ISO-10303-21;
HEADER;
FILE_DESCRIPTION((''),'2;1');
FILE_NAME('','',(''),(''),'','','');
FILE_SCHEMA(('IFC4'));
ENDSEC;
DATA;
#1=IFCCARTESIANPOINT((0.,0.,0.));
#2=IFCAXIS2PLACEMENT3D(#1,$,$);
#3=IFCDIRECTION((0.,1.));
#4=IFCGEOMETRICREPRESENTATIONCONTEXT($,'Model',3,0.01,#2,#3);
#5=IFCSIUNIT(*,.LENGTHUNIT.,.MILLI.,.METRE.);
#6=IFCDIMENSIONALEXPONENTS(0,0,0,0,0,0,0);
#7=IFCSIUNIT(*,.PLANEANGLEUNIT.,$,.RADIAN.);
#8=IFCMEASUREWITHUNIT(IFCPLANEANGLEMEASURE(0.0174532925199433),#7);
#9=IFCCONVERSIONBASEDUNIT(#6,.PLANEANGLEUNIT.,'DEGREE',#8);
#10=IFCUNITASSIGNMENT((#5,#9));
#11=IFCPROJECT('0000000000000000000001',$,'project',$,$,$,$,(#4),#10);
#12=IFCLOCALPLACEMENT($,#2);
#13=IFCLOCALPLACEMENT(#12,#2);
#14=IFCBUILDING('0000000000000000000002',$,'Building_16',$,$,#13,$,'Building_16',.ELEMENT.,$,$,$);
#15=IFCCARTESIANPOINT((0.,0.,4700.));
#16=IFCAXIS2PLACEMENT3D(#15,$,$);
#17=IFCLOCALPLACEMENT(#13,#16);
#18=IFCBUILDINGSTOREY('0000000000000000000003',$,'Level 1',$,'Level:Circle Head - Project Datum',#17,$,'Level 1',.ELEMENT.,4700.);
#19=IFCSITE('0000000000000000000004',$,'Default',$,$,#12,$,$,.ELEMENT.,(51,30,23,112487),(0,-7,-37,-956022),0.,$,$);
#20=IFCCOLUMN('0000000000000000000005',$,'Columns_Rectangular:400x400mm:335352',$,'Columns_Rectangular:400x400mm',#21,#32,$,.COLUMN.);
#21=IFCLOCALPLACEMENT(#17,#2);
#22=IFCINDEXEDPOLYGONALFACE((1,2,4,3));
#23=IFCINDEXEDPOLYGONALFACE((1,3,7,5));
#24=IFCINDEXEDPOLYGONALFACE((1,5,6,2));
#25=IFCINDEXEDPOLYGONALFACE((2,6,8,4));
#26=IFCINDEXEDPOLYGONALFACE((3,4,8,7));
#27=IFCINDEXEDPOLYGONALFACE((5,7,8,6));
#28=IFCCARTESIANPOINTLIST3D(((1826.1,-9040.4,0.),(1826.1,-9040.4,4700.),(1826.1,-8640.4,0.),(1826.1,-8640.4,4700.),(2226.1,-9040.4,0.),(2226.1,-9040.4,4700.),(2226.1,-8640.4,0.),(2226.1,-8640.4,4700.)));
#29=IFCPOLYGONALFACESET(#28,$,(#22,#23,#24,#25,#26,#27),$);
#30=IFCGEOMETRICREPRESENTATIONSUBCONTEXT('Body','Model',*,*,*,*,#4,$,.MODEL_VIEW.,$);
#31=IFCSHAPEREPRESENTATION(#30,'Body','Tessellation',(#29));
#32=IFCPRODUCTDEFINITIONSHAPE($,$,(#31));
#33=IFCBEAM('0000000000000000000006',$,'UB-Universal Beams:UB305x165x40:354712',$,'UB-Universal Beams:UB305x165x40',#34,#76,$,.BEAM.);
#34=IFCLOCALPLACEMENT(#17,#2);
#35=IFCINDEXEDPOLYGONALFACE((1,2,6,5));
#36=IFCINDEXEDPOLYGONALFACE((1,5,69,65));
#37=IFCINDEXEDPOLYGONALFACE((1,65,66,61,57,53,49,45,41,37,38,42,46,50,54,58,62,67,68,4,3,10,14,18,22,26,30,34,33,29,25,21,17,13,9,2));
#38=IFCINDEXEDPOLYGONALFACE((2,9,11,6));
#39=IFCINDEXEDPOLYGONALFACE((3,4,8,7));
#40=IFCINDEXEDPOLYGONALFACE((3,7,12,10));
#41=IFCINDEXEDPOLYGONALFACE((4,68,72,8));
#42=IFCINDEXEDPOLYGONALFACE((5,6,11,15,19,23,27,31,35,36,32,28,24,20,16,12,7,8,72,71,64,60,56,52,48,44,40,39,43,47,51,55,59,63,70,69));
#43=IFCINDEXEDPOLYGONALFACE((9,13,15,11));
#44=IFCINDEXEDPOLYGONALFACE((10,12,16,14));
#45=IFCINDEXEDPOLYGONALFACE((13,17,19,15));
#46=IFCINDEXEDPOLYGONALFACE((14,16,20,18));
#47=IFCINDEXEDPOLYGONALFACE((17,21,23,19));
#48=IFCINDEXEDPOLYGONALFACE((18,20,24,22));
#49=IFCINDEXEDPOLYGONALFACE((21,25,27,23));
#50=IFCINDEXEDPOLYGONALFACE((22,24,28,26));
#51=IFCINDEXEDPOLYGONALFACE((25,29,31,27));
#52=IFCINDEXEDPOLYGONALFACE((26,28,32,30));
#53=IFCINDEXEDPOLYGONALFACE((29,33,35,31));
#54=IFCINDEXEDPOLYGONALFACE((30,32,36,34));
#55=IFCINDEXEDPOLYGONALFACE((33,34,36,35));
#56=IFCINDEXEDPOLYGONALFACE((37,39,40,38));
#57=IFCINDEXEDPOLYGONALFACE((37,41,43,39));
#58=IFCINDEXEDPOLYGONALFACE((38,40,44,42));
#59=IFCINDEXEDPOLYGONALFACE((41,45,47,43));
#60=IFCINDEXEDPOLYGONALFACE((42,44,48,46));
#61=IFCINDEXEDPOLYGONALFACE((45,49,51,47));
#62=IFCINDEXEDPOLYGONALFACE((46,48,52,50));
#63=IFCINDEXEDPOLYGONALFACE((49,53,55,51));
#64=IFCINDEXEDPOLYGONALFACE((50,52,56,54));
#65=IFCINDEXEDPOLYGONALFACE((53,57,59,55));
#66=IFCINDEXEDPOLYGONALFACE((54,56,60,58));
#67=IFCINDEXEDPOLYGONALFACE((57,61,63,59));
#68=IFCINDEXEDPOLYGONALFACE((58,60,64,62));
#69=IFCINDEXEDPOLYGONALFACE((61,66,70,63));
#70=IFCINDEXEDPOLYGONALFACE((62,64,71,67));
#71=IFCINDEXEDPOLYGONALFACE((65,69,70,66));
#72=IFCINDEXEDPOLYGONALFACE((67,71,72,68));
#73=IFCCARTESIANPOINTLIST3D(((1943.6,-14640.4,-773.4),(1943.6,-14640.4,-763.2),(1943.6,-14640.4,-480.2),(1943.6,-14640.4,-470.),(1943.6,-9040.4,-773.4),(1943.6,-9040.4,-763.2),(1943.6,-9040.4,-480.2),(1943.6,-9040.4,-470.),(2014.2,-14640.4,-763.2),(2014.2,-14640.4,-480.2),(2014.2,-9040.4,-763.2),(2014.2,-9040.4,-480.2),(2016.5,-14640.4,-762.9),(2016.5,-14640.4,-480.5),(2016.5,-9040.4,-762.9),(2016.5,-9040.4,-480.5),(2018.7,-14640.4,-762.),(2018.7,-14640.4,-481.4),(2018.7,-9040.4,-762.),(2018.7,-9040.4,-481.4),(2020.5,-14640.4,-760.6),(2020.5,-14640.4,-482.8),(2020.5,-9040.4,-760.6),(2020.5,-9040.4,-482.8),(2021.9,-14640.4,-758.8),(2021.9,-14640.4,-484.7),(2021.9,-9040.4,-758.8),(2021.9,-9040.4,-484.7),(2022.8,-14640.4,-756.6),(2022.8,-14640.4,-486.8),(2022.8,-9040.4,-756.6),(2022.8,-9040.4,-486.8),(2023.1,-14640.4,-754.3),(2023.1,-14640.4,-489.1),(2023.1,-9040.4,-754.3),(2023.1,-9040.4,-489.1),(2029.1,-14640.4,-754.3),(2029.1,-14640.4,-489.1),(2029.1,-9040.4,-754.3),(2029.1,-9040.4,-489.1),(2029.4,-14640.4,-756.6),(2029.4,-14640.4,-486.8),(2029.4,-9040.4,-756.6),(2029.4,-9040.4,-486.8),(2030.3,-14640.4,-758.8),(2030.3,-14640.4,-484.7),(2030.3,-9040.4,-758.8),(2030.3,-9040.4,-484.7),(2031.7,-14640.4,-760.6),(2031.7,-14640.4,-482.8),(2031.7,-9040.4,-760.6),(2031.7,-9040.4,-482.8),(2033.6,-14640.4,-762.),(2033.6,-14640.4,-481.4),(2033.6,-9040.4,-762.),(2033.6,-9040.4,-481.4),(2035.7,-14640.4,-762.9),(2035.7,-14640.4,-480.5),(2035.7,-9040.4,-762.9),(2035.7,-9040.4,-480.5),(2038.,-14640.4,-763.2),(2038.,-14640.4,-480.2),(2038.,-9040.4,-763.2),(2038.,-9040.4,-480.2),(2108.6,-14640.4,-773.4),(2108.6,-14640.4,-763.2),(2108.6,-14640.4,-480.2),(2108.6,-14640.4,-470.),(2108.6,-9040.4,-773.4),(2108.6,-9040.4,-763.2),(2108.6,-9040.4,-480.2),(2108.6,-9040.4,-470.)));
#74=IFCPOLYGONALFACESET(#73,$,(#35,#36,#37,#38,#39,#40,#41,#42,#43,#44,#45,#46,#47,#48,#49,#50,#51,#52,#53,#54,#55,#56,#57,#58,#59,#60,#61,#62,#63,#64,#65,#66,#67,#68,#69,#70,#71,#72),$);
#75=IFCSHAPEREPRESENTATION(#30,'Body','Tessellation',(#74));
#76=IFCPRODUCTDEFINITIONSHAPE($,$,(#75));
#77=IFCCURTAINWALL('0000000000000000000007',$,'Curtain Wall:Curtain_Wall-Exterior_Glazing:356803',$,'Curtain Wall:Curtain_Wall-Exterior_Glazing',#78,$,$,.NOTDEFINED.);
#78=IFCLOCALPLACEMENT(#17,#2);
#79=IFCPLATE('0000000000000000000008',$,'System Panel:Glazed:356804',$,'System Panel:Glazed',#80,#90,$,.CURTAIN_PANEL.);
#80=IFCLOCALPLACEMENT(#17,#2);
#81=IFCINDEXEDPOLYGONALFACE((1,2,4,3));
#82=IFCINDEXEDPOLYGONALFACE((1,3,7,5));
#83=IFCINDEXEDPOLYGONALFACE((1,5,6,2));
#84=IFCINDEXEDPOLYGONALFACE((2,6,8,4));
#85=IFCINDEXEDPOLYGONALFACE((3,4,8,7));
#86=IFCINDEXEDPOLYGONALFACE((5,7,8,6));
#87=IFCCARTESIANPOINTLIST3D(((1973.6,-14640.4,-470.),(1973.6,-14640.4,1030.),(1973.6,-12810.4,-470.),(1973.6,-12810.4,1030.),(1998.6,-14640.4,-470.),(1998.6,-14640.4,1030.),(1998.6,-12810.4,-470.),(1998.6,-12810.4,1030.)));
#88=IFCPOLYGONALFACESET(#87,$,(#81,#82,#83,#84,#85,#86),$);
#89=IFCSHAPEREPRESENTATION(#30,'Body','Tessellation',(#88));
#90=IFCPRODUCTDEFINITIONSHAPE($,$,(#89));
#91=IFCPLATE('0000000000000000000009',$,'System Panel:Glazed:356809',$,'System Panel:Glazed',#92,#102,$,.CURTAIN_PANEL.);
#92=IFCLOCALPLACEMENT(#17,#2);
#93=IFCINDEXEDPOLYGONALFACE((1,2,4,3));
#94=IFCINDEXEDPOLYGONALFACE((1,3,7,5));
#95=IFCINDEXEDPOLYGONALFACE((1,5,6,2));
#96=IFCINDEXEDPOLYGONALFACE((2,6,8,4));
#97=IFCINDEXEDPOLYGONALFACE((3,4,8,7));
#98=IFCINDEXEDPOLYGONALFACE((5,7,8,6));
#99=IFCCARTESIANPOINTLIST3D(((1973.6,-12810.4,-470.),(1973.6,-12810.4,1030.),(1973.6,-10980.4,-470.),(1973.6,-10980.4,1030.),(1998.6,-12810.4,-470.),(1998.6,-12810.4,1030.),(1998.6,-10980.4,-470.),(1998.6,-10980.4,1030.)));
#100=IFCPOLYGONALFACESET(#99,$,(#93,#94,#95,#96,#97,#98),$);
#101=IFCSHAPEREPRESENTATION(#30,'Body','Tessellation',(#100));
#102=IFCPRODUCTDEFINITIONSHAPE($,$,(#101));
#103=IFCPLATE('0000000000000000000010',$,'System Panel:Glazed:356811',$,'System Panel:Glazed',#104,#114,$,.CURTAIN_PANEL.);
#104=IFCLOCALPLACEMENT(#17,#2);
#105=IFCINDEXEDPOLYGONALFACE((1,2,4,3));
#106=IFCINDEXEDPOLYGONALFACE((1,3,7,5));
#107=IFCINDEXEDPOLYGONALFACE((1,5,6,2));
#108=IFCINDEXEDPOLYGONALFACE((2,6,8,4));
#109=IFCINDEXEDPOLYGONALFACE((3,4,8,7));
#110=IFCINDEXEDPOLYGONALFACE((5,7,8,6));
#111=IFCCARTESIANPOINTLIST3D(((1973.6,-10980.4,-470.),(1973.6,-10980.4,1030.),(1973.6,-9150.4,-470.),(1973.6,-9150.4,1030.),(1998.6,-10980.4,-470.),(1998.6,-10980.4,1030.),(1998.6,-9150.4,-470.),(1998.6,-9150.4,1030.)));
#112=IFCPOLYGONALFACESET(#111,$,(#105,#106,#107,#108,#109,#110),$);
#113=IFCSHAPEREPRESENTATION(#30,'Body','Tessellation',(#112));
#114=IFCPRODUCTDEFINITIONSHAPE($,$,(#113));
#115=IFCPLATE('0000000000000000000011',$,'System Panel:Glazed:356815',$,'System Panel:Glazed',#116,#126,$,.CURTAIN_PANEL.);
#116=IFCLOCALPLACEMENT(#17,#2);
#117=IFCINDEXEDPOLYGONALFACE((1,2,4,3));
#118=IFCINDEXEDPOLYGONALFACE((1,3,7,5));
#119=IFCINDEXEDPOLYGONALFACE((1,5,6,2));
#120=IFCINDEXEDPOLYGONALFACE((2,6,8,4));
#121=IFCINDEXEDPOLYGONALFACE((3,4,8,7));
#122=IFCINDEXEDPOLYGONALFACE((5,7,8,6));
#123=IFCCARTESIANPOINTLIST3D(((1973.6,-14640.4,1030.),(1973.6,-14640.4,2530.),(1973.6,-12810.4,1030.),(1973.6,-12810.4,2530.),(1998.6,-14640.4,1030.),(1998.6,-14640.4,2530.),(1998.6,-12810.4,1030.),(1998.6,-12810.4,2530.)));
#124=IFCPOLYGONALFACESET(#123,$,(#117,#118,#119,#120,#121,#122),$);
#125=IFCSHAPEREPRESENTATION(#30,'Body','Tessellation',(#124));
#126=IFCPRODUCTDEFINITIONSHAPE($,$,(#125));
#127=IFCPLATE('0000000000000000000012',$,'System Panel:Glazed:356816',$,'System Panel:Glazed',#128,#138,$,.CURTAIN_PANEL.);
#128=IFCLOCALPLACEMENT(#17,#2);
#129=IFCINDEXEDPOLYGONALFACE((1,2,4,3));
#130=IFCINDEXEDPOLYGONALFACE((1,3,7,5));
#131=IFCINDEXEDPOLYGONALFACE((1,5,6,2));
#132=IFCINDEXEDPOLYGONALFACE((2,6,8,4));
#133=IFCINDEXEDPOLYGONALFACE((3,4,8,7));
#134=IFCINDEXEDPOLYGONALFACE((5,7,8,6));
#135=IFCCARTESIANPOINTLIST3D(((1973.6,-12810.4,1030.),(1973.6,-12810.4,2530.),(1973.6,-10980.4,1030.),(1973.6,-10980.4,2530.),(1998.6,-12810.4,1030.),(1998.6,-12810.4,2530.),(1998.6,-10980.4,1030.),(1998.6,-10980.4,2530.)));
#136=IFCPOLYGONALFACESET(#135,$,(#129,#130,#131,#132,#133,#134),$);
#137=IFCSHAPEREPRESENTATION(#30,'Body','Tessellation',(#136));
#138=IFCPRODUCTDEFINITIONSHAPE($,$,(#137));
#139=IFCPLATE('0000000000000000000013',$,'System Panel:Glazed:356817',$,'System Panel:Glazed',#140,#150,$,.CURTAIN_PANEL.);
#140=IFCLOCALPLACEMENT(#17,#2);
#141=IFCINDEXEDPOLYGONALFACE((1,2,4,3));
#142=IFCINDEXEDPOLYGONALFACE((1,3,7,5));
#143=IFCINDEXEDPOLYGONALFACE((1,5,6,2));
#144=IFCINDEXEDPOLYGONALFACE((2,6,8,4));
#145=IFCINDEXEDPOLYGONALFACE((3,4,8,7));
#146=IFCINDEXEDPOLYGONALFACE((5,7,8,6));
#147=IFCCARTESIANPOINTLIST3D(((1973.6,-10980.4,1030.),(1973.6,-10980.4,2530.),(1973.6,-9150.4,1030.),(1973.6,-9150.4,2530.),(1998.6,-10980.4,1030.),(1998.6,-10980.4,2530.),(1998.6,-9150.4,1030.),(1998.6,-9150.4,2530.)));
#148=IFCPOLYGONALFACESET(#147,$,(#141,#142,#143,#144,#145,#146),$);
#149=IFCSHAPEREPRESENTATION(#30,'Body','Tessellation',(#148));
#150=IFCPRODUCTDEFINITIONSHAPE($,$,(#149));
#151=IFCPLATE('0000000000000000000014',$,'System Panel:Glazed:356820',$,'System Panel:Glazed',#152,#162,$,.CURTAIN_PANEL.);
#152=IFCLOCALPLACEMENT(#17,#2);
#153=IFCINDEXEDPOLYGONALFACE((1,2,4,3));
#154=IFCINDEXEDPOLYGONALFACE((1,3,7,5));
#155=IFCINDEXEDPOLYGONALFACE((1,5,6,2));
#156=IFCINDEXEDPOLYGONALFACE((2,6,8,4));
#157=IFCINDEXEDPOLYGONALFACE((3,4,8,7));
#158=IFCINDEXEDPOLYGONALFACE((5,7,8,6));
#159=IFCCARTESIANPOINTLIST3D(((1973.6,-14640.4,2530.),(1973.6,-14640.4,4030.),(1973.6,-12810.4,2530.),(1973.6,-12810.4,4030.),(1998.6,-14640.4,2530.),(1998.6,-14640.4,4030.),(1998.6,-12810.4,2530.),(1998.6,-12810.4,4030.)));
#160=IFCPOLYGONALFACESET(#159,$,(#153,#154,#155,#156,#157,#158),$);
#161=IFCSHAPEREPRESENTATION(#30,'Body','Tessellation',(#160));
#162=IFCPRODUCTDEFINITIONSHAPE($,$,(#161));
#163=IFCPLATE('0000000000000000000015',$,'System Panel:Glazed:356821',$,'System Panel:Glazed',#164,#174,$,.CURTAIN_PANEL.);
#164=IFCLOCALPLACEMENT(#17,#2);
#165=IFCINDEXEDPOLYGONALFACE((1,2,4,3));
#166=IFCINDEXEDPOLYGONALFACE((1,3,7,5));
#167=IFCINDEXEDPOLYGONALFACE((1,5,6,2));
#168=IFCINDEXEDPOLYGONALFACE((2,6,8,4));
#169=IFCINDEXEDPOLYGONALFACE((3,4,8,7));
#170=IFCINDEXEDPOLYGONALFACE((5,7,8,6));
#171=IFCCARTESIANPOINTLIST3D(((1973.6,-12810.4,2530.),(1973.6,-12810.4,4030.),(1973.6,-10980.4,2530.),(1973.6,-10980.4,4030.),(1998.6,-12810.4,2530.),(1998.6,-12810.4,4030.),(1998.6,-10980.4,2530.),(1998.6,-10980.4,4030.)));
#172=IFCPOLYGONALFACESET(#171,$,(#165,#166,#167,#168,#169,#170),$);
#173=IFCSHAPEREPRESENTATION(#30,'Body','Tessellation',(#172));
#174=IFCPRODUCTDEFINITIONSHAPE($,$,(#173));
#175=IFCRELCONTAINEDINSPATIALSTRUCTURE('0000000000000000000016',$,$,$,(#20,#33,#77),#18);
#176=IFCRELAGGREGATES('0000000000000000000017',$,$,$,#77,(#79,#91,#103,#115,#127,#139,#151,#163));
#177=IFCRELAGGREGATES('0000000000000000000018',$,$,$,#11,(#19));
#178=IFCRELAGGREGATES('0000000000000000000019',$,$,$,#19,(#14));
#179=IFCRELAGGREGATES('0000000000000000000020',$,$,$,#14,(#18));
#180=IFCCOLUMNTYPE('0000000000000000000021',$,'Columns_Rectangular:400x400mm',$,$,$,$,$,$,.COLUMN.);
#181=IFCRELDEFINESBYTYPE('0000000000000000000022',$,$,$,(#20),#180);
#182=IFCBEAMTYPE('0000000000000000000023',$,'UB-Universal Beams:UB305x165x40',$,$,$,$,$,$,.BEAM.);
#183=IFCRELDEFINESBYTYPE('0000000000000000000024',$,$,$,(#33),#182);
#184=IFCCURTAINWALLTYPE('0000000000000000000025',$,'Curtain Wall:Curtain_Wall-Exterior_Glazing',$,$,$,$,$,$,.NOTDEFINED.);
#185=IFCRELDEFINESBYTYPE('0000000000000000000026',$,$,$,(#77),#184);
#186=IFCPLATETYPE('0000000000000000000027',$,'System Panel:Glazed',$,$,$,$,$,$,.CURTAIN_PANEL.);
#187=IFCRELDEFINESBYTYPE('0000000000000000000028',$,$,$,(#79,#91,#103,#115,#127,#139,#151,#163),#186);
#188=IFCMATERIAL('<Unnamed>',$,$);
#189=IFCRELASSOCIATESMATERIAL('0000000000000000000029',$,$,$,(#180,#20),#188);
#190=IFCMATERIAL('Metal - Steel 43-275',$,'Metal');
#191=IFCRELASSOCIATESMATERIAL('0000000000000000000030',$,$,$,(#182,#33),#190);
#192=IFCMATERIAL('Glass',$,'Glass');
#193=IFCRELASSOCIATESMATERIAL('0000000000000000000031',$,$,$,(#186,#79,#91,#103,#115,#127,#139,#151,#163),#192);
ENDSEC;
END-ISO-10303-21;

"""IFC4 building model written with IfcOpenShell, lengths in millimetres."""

from ifc_helpers import new_model, entity, si_unit, converted_unit, direction, frame, origin, place, context, subcontext, project, spatial, line, arc, indexed_curve, outline, extrude, source, transform, mapped, material, type_object, type_shapes, element, aggregate, save


model = new_model("IFC4")

# Units and contexts
model_context = context("Model", 3, precision=0.01, world=origin(), true_north=direction((0.0, 1.0)))
body_context = subcontext(model_context, "Body", "Model", "MODEL_VIEW")
ifc_project = project(units=[si_unit("LENGTHUNIT", "METRE", prefix="MILLI"), converted_unit("PLANEANGLEUNIT", "DEGREE", entity("IfcPlaneAngleMeasure", 0.0174532925199433), si_unit("PLANEANGLEUNIT", "RADIAN"), dimensions=[0, 0, 0, 0, 0, 0, 0])], contexts=[model_context])

# Site, building, storey
site_placement = place(None, origin())
site = spatial("IfcSite", under=ifc_project, at=site_placement, Name="Default", CompositionType="ELEMENT", RefLatitude=(51, 30, 23, 112487), RefLongitude=(0, -7, -37, -956022), RefElevation=0.0)
building_placement = place(site_placement, origin())
building = spatial("IfcBuilding", under=site, at=building_placement, Name="Building_16", LongName="Building_16", CompositionType="ELEMENT")
storey_placement = place(building_placement, frame((0.0, 0.0, 4700.0)))
storey = spatial("IfcBuildingStorey", under=building, at=storey_placement, Name="Level 1", ObjectType="Level:Circle Head - Project Datum", LongName="Level 1", CompositionType="ELEMENT", Elevation=4700.0)

# Column
ifc_material_1 = material(Name="<Unnamed>")
column_type = type_object("IfcColumnType", Name="Columns_Rectangular:400x400mm", PredefinedType="COLUMN", material=ifc_material_1)
shared_shape_1 = source(origin(), body_context, "Body", "SweptSolid", [
    extrude(outline(indexed_curve([(-200.0, -200.0), (200.0, -200.0), (200.0, 200.0), (-200.0, 200.0), (-200.0, -200.0)], self_intersect=False)), frame((0.0, 0.0, 4700.0), z_axis=(0.0, 0.0, 1.0), x_axis=(-1.0, 0.0, 0.0)), (0.0, 0.0, 1.0), 4700.0),
])
type_shapes(column_type, [shared_shape_1])
column_placement = place(storey_placement, frame((2026.1, -8840.4, -4700.0)))
element("IfcColumn", 1, at=column_placement, inside=storey, type_object=column_type, material=ifc_material_1, Name="Columns_Rectangular:400x400mm:335352", ObjectType="Columns_Rectangular:400x400mm", PredefinedType="COLUMN", context=body_context, shape_type="MappedRepresentation", body=[
    mapped(shared_shape_1, transform((0.0, 0.0, 0.0), scale=1.0)),
])

# Beam
ifc_material_2 = material(Name="Metal - Steel 43-275", Category="Metal")
beam_type = type_object("IfcBeamType", Name="UB-Universal Beams:UB305x165x40", PredefinedType="BEAM", material=ifc_material_2)
shared_shape_2 = source(origin(), body_context, "Body", "SweptSolid", [
    extrude(outline(indexed_curve([(-82.5, -141.5), (-82.5, -151.7), (82.5, -151.7), (82.5, -141.5), (11.9, -141.5), (5.6, -138.9), (3.0, -132.6), (3.0, 132.6), (5.6, 138.9), (11.9, 141.5), (82.5, 141.5), (82.5, 151.7), (-82.5, 151.7), (-82.5, 141.5), (-11.9, 141.5), (-5.6, 138.9), (-3.0, 132.6), (-3.0, -132.6), (-5.6, -138.9), (-11.9, -141.5)], segments=[line(1, 2, 3, 4, 5), arc(5, 6, 7), line(7, 8), arc(8, 9, 10), line(10, 11, 12, 13, 14, 15), arc(15, 16, 17), line(17, 18), arc(18, 19, 20), line(20, 1)], self_intersect=False)), frame((-2800.0, 0.0, 0.0), z_axis=(-1.0, 0.0, 0.0), x_axis=(0.0, -1.0, 0.0)), (0.0, 0.0, -1.0), 5600.0),
])
type_shapes(beam_type, [shared_shape_2])
beam_placement = place(storey_placement, frame((2026.1, -11840.4, -621.7), z_axis=(0.0, 0.0, 1.0), x_axis=(0.0, 1.0, 0.0)))
element("IfcBeam", 2, at=beam_placement, inside=storey, type_object=beam_type, material=ifc_material_2, Name="UB-Universal Beams:UB305x165x40:354712", ObjectType="UB-Universal Beams:UB305x165x40", PredefinedType="BEAM", context=body_context, shape_type="MappedRepresentation", body=[
    mapped(shared_shape_2, transform((0.0, 0.0, 0.0), scale=1.0)),
])

# Curtain wall, plates
curtain_wall_type = type_object("IfcCurtainWallType", Name="Curtain Wall:Curtain_Wall-Exterior_Glazing", PredefinedType="NOTDEFINED")
curtain_wall_1_placement = place(storey_placement, frame((0.0, 0.0, -4700.0)))
curtain_wall_1 = element("IfcCurtainWall", 3, at=curtain_wall_1_placement, inside=storey, type_object=curtain_wall_type, Name="Curtain Wall:Curtain_Wall-Exterior_Glazing:356803", ObjectType="Curtain Wall:Curtain_Wall-Exterior_Glazing", PredefinedType="NOTDEFINED")
ifc_material_3 = material(Name="Glass", Category="Glass")
plate_type_1 = type_object("IfcPlateType", Name="System Panel:Glazed", PredefinedType="CURTAIN_PANEL", material=ifc_material_3)
shared_shape_3 = source(origin(), body_context, "Body", "SweptSolid", [
    extrude(outline(indexed_curve([(-12.5, -915.0), (12.5, -915.0), (12.5, 915.0), (-12.5, 915.0), (-12.5, -915.0)], self_intersect=False)), frame((0.0, 37.0, 0.0), z_axis=(0.0, 0.0, 1.0), x_axis=(0.0, 1.0, 0.0)), (0.0, 0.0, 1.0), 1500.0),
])
type_shapes(plate_type_1, [shared_shape_3])
plate_1_placement = place(curtain_wall_1_placement, frame((2023.1, -13725.4, 4230.0), z_axis=(0.0, 0.0, 1.0), x_axis=(0.0, 1.0, 0.0)))
plate_1 = element("IfcPlate", 4, at=plate_1_placement, type_object=plate_type_1, material=ifc_material_3, Name="System Panel:Glazed:356804", ObjectType="System Panel:Glazed", PredefinedType="CURTAIN_PANEL", context=body_context, shape_type="MappedRepresentation", body=[
    mapped(shared_shape_3, transform((0.0, 0.0, 0.0), scale=1.0)),
])
plate_2_placement = place(curtain_wall_1_placement, frame((2023.1, -11895.4, 4230.0), z_axis=(0.0, 0.0, 1.0), x_axis=(0.0, 1.0, 0.0)))
plate_2 = element("IfcPlate", 5, at=plate_2_placement, type_object=plate_type_1, material=ifc_material_3, Name="System Panel:Glazed:356809", ObjectType="System Panel:Glazed", PredefinedType="CURTAIN_PANEL", context=body_context, shape_type="MappedRepresentation", body=[
    mapped(shared_shape_3, transform((0.0, 0.0, 0.0), scale=1.0)),
])
plate_3_placement = place(curtain_wall_1_placement, frame((2023.1, -10065.4, 4230.0), z_axis=(0.0, 0.0, 1.0), x_axis=(0.0, 1.0, 0.0)))
plate_3 = element("IfcPlate", 6, at=plate_3_placement, type_object=plate_type_1, material=ifc_material_3, Name="System Panel:Glazed:356811", ObjectType="System Panel:Glazed", PredefinedType="CURTAIN_PANEL", context=body_context, shape_type="MappedRepresentation", body=[
    mapped(shared_shape_3, transform((0.0, 0.0, 0.0), scale=1.0)),
])
plate_4_placement = place(curtain_wall_1_placement, frame((2023.1, -13725.4, 5730.0), z_axis=(0.0, 0.0, 1.0), x_axis=(0.0, 1.0, 0.0)))
plate_4 = element("IfcPlate", 7, at=plate_4_placement, type_object=plate_type_1, material=ifc_material_3, Name="System Panel:Glazed:356815", ObjectType="System Panel:Glazed", PredefinedType="CURTAIN_PANEL", context=body_context, shape_type="MappedRepresentation", body=[
    mapped(shared_shape_3, transform((0.0, 0.0, 0.0), scale=1.0)),
])
plate_5_placement = place(curtain_wall_1_placement, frame((2023.1, -11895.4, 5730.0), z_axis=(0.0, 0.0, 1.0), x_axis=(0.0, 1.0, 0.0)))
plate_5 = element("IfcPlate", 8, at=plate_5_placement, type_object=plate_type_1, material=ifc_material_3, Name="System Panel:Glazed:356816", ObjectType="System Panel:Glazed", PredefinedType="CURTAIN_PANEL", context=body_context, shape_type="MappedRepresentation", body=[
    mapped(shared_shape_3, transform((0.0, 0.0, 0.0), scale=1.0)),
])
plate_6_placement = place(curtain_wall_1_placement, frame((2023.1, -10065.4, 5730.0), z_axis=(0.0, 0.0, 1.0), x_axis=(0.0, 1.0, 0.0)))
plate_6 = element("IfcPlate", 9, at=plate_6_placement, type_object=plate_type_1, material=ifc_material_3, Name="System Panel:Glazed:356817", ObjectType="System Panel:Glazed", PredefinedType="CURTAIN_PANEL", context=body_context, shape_type="MappedRepresentation", body=[
    mapped(shared_shape_3, transform((0.0, 0.0, 0.0), scale=1.0)),
])
plate_7_placement = place(curtain_wall_1_placement, frame((2023.1, -13725.4, 7230.0), z_axis=(0.0, 0.0, 1.0), x_axis=(0.0, 1.0, 0.0)))
plate_7 = element("IfcPlate", 10, at=plate_7_placement, type_object=plate_type_1, material=ifc_material_3, Name="System Panel:Glazed:356820", ObjectType="System Panel:Glazed", PredefinedType="CURTAIN_PANEL", context=body_context, shape_type="MappedRepresentation", body=[
    mapped(shared_shape_3, transform((0.0, 0.0, 0.0), scale=1.0)),
])
plate_8_placement = place(curtain_wall_1_placement, frame((2023.1, -11895.4, 7230.0), z_axis=(0.0, 0.0, 1.0), x_axis=(0.0, 1.0, 0.0)))
plate_8 = element("IfcPlate", 11, at=plate_8_placement, type_object=plate_type_1, material=ifc_material_3, Name="System Panel:Glazed:356821", ObjectType="System Panel:Glazed", PredefinedType="CURTAIN_PANEL", context=body_context, shape_type="MappedRepresentation", body=[
    mapped(shared_shape_3, transform((0.0, 0.0, 0.0), scale=1.0)),
])

aggregate(curtain_wall_1, [plate_1, plate_2, plate_3, plate_4, plate_5, plate_6, plate_7, plate_8])

save(model, "model.ifc")
